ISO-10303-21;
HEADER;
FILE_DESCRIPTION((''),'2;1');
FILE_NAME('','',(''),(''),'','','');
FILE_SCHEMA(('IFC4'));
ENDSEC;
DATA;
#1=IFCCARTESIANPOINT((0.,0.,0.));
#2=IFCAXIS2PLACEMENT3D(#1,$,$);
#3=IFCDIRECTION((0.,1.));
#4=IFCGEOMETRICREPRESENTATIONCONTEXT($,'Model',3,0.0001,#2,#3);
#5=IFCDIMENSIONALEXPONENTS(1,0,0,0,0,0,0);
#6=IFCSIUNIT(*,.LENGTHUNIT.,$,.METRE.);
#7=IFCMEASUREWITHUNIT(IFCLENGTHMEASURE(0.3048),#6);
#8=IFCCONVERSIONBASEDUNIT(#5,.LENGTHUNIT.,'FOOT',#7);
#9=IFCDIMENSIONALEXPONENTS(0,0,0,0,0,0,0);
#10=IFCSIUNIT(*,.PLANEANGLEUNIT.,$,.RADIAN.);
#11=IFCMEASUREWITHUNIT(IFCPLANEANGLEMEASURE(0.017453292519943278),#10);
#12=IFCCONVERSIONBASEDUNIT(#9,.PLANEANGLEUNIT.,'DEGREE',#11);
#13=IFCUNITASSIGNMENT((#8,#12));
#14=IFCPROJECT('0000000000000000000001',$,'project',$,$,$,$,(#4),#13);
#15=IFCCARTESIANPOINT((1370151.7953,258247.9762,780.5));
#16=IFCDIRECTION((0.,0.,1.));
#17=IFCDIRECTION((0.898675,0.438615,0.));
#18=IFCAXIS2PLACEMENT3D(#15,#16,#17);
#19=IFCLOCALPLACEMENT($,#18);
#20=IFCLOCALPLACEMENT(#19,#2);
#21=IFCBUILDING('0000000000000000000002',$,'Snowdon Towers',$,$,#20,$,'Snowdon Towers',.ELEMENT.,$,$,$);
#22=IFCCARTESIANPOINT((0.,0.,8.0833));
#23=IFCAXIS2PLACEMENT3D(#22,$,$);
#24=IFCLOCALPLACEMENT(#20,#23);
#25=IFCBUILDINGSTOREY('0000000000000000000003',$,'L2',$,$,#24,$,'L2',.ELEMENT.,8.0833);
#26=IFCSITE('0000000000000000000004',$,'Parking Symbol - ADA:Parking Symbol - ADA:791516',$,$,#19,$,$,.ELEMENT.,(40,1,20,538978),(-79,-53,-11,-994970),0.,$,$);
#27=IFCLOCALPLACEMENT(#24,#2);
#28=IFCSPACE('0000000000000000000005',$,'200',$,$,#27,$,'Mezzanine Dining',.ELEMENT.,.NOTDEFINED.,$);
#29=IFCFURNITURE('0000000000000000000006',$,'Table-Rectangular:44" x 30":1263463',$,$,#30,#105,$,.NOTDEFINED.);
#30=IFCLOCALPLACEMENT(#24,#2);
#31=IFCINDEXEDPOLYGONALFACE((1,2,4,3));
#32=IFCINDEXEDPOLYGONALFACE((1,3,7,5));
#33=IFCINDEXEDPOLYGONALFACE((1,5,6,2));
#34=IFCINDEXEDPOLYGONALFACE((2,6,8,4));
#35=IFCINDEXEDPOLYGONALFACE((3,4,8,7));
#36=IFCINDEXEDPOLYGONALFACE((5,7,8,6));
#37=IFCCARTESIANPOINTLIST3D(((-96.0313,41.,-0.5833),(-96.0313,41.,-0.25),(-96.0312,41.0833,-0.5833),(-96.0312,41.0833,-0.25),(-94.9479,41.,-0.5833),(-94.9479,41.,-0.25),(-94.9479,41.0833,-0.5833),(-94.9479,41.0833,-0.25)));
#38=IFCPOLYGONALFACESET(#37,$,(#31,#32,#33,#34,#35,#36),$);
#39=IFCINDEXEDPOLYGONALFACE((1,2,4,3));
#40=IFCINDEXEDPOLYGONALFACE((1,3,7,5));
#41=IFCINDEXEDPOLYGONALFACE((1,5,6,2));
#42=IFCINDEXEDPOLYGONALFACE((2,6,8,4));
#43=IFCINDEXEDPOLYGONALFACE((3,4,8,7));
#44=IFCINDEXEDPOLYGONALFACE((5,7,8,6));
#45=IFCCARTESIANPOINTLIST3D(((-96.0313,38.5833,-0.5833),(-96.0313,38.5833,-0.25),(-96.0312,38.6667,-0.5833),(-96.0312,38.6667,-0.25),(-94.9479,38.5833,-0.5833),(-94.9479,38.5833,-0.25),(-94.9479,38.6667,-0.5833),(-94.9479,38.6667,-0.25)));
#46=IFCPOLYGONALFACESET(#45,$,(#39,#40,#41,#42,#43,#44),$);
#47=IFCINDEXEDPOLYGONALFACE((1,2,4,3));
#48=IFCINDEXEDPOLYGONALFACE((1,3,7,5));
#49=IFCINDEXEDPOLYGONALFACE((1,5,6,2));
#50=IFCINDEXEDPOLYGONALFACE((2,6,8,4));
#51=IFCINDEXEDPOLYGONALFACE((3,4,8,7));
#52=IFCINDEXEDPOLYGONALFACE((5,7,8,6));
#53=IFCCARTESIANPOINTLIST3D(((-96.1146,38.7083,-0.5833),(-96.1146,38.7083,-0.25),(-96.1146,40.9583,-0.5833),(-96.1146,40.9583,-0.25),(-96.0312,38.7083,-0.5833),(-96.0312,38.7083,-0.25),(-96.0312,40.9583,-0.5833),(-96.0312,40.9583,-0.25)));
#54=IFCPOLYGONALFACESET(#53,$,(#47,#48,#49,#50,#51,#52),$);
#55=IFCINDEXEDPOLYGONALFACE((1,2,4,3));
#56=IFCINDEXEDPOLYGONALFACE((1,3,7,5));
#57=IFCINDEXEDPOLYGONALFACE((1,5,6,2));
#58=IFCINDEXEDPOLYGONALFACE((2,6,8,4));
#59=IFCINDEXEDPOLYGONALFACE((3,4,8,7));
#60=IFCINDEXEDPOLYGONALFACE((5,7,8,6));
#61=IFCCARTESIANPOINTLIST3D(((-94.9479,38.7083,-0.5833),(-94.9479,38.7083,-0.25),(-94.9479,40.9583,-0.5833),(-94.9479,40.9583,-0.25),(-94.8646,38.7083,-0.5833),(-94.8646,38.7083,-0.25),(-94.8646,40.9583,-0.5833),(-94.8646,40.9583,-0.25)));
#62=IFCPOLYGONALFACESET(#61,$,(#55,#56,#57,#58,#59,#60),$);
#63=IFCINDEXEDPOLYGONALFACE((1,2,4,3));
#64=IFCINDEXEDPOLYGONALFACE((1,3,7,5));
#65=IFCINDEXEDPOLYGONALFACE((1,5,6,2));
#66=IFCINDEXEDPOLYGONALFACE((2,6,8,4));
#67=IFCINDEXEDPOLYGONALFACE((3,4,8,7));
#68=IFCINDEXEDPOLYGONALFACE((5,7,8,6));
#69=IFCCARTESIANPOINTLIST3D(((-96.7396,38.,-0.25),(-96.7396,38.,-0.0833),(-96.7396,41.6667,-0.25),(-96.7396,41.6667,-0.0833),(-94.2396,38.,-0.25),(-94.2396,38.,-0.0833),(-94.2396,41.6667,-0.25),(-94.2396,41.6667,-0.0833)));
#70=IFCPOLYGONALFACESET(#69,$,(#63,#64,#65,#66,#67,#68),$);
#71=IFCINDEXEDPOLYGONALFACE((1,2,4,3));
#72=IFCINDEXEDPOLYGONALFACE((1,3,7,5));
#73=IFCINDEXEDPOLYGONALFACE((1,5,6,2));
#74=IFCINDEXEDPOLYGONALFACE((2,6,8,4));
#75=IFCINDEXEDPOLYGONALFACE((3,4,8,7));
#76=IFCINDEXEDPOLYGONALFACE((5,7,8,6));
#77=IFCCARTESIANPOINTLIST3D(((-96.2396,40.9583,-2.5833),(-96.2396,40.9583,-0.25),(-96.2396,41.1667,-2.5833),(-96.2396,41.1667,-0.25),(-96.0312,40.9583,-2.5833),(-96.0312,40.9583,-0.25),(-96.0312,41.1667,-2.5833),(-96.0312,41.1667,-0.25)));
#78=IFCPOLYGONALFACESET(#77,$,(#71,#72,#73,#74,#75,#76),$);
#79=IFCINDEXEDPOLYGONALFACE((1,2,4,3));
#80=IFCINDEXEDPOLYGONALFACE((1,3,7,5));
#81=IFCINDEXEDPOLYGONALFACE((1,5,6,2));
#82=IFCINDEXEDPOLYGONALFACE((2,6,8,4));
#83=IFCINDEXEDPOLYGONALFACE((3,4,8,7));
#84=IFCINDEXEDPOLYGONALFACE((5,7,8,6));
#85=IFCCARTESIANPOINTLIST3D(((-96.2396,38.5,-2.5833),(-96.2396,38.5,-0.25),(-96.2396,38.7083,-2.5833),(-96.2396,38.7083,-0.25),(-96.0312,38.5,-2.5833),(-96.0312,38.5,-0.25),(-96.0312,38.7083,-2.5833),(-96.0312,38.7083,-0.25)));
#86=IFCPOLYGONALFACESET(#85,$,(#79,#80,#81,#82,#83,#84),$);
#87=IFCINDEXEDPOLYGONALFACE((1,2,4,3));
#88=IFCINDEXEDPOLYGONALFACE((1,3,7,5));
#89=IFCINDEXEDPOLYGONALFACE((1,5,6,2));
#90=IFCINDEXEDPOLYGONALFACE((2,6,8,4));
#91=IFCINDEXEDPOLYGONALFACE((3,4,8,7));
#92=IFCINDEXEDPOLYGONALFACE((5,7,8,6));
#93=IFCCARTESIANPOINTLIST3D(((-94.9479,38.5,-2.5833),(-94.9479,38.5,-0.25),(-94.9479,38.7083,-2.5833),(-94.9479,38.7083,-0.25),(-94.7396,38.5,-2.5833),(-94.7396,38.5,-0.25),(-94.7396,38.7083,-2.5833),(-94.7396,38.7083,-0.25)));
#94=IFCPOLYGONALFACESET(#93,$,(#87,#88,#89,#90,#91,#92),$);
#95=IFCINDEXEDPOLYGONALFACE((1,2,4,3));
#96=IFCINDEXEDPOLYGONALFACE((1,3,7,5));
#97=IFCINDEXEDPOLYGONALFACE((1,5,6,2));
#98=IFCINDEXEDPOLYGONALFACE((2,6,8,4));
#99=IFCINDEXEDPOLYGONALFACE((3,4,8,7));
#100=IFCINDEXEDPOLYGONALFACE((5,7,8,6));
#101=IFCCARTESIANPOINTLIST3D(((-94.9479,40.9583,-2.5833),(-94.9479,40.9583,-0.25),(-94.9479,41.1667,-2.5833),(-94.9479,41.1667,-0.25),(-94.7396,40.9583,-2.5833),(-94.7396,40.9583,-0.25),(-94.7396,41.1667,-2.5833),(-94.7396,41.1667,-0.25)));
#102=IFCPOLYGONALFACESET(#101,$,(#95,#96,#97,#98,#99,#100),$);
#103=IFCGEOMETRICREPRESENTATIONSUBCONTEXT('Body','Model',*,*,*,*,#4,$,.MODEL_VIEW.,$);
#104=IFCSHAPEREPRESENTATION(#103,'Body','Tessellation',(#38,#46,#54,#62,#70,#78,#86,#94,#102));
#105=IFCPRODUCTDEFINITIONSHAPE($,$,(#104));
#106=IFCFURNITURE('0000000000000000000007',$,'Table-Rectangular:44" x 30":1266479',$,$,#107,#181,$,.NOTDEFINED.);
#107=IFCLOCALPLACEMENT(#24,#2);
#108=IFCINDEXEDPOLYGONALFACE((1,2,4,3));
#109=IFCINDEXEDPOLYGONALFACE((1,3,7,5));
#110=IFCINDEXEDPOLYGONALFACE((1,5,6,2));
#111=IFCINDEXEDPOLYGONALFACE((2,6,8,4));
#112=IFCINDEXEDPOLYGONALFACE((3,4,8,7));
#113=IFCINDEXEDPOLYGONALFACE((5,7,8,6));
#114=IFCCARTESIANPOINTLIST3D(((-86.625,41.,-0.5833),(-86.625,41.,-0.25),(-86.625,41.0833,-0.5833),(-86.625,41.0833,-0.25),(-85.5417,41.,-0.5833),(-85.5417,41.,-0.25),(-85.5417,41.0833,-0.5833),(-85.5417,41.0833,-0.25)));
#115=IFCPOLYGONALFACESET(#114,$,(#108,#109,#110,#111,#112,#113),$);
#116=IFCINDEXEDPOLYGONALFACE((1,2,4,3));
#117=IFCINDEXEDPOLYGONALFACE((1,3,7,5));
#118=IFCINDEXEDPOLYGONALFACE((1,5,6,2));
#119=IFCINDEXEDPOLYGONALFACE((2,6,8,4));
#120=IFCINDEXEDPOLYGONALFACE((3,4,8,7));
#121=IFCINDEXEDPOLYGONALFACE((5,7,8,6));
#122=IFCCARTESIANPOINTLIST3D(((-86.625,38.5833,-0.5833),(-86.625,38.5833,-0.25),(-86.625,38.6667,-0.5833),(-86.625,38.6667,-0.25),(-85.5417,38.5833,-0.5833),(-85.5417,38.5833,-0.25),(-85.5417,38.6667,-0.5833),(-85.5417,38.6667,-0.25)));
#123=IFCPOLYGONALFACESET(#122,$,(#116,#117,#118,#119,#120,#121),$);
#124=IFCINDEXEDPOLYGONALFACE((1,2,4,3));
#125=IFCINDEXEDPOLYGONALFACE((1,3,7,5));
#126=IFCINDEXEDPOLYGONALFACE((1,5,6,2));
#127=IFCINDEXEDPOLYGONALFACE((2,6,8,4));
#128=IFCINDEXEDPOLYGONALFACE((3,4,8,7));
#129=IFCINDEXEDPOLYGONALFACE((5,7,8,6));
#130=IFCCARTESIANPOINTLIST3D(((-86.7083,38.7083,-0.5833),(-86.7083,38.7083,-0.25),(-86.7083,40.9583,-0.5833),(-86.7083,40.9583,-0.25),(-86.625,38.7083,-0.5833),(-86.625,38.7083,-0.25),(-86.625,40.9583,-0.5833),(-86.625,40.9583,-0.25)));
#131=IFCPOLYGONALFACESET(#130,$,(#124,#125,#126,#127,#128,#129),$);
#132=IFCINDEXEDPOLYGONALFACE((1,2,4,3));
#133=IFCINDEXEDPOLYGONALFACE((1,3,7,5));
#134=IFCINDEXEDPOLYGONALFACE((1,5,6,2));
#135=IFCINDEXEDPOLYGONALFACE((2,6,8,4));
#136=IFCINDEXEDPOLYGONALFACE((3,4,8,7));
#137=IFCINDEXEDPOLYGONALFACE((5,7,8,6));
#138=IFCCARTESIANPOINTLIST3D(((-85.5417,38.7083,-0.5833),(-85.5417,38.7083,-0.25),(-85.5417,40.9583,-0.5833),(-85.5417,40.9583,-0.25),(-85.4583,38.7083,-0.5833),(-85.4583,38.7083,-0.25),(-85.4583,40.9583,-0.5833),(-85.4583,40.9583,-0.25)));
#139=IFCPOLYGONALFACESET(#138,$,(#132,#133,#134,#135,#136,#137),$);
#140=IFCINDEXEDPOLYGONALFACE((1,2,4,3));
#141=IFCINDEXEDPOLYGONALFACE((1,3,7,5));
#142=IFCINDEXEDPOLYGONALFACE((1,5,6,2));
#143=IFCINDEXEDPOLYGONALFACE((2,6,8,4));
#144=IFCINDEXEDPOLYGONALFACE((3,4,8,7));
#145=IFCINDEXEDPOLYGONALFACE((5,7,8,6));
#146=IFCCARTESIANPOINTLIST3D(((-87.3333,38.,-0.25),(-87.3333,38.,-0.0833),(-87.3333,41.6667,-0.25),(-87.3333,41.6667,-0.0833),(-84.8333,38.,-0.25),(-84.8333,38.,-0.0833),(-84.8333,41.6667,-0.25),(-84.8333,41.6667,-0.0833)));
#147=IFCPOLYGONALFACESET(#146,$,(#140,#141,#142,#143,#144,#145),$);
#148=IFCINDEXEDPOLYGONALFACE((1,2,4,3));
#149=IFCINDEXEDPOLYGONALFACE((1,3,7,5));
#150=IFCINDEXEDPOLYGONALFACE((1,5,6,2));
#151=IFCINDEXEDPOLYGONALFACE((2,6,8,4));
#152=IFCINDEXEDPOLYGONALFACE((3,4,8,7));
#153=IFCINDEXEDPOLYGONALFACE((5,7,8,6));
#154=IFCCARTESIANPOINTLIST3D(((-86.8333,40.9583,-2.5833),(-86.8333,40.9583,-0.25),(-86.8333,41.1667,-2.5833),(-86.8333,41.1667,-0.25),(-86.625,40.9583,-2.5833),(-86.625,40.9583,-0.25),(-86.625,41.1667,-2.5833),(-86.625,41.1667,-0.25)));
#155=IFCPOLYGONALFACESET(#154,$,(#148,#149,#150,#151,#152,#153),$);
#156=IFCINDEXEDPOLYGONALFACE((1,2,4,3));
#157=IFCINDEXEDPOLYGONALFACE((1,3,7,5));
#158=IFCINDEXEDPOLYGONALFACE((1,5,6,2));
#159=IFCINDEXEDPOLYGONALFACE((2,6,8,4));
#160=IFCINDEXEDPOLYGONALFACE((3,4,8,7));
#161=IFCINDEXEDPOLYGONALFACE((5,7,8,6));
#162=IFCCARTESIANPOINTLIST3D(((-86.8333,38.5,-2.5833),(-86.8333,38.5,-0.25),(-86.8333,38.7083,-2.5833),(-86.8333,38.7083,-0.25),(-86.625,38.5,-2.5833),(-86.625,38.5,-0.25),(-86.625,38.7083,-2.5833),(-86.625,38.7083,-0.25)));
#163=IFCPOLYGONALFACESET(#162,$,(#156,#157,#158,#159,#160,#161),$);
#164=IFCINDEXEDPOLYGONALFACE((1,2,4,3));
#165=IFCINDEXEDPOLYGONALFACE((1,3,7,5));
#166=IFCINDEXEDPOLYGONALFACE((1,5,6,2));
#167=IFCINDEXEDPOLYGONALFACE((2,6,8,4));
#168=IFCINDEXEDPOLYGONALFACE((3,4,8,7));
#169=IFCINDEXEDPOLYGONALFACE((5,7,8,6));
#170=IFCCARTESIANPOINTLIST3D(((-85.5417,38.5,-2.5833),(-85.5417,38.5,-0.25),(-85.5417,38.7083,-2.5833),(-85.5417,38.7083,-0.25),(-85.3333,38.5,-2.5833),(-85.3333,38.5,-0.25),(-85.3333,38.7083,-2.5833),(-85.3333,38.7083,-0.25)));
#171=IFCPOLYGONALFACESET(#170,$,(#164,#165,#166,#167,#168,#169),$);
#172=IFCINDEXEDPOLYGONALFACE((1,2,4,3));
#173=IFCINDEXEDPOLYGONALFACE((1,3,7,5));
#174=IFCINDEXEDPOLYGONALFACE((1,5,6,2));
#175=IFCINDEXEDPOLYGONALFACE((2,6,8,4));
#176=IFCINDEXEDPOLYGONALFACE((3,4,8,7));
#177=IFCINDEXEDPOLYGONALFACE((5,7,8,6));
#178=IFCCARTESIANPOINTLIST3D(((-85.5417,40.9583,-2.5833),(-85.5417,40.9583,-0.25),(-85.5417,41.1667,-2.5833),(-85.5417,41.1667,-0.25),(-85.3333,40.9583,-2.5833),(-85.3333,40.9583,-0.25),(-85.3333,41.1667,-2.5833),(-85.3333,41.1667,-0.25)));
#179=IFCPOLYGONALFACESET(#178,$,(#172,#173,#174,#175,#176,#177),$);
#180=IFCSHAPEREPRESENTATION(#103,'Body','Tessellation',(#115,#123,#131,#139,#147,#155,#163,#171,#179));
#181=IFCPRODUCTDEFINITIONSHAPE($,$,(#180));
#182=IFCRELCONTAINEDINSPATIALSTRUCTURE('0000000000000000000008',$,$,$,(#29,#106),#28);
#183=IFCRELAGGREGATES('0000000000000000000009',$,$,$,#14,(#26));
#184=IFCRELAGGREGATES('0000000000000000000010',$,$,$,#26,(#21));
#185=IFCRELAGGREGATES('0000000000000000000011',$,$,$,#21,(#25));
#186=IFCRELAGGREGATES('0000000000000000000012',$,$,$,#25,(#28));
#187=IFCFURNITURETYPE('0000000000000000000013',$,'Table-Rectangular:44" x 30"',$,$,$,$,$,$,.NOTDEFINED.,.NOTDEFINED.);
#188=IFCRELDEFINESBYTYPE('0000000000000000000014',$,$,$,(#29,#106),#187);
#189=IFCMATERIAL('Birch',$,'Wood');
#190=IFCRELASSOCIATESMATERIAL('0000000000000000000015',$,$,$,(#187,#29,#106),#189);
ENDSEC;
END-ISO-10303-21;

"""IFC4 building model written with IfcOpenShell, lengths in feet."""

from ifc_helpers import new_model, entity, si_unit, converted_unit, direction, frame, origin, place, context, subcontext, project, spatial, indexed_curve, outline, extrude, source, transform, mapped, material, type_object, type_shapes, element, save


model = new_model("IFC4")

# Units and contexts
model_context = context("Model", 3, precision=0.0001, world=origin(), true_north=direction((0.0, 1.0)))
body_context = subcontext(model_context, "Body", "Model", "MODEL_VIEW")
ifc_project = project(units=[converted_unit("LENGTHUNIT", "FOOT", entity("IfcLengthMeasure", 0.3048), si_unit("LENGTHUNIT", "METRE"), dimensions=[1, 0, 0, 0, 0, 0, 0]), converted_unit("PLANEANGLEUNIT", "DEGREE", entity("IfcPlaneAngleMeasure", 0.017453292519943278), si_unit("PLANEANGLEUNIT", "RADIAN"), dimensions=[0, 0, 0, 0, 0, 0, 0])], contexts=[model_context])

# Site, building, storey
site_placement = place(None, frame((1370151.7953, 258247.9762, 780.5), z_axis=(0.0, 0.0, 1.0), x_axis=(0.898675, 0.438615, 0.0)))
site = spatial("IfcSite", under=ifc_project, at=site_placement, Name="Parking Symbol - ADA:Parking Symbol - ADA:791516", CompositionType="ELEMENT", RefLatitude=(40, 1, 20, 538978), RefLongitude=(-79, -53, -11, -994970), RefElevation=0.0)
building_placement = place(site_placement, origin())
building = spatial("IfcBuilding", under=site, at=building_placement, Name="Snowdon Towers", LongName="Snowdon Towers", CompositionType="ELEMENT")
storey_placement = place(building_placement, frame((0.0, 0.0, 8.0833)))
storey = spatial("IfcBuildingStorey", under=building, at=storey_placement, Name="L2", LongName="L2", CompositionType="ELEMENT", Elevation=8.0833)

# Shared definitions
space_1_placement = place(storey_placement, origin())
space_1 = spatial("IfcSpace", under=storey, at=space_1_placement, Name="200", LongName="Mezzanine Dining", CompositionType="ELEMENT", PredefinedType="NOTDEFINED")

# Furniture
ifc_material_1 = material(Name="Birch", Category="Wood")
furniture_type_1 = type_object("IfcFurnitureType", Name="Table-Rectangular:44\" x 30\"", AssemblyPlace="NOTDEFINED", PredefinedType="NOTDEFINED", material=ifc_material_1)
shared_shape_1 = source(origin(), body_context, "Body", "SweptSolid", [
    extrude(outline(indexed_curve([(-0.0417, -0.5417), (0.0417, -0.5417), (0.0417, 0.5417), (-0.0417, 0.5417), (-0.0417, -0.5417)], self_intersect=False)), frame((1.2083, 0.0, 2.0)), (0.0, 0.0, 1.0), 0.3333),
    extrude(outline(indexed_curve([(-0.5417, -0.0417), (0.5417, -0.0417), (0.5417, 0.0417), (-0.5417, 0.0417), (-0.5417, -0.0417)], self_intersect=False)), frame((-1.2083, 0.0, 2.0), z_axis=(0.0, 0.0, 1.0), x_axis=(0.0, 1.0, 0.0)), (0.0, 0.0, 1.0), 0.3333),
    extrude(outline(indexed_curve([(-1.125, -0.0417), (1.125, -0.0417), (1.125, 0.0417), (-1.125, 0.0417), (-1.125, -0.0417)], self_intersect=False)), frame((0.0, 0.5833, 2.0), z_axis=(0.0, 0.0, 1.0), x_axis=(-1.0, 0.0, 0.0)), (0.0, 0.0, 1.0), 0.3333),
    extrude(outline(indexed_curve([(-0.0417, -1.125), (0.0417, -1.125), (0.0417, 1.125), (-0.0417, 1.125), (-0.0417, -1.125)], self_intersect=False)), frame((0.0, -0.5833, 2.0), z_axis=(0.0, 0.0, 1.0), x_axis=(0.0, 1.0, 0.0)), (0.0, 0.0, 1.0), 0.3333),
    extrude(outline(indexed_curve([(-1.8333, -1.25), (1.8333, -1.25), (1.8333, 1.25), (-1.8333, 1.25), (-1.8333, -1.25)], self_intersect=False)), frame((0.0, 0.0, 2.3333), z_axis=(0.0, 0.0, 1.0), x_axis=(-1.0, 0.0, 0.0)), (0.0, 0.0, 1.0), 0.1667),
    extrude(outline(indexed_curve([(-0.1042, -0.1042), (0.1042, -0.1042), (0.1042, 0.1042), (-0.1042, 0.1042), (-0.1042, -0.1042)], self_intersect=False)), frame((1.2292, 0.6458, 0.0), z_axis=(0.0, 0.0, 1.0), x_axis=(0.0, -1.0, 0.0)), (0.0, 0.0, 1.0), 2.3333),
    extrude(outline(indexed_curve([(-0.1042, -0.1042), (0.1042, -0.1042), (0.1042, 0.1042), (-0.1042, 0.1042), (-0.1042, -0.1042)], self_intersect=False)), frame((-1.2292, 0.6458, 0.0), z_axis=(0.0, 0.0, 1.0), x_axis=(-1.0, 0.0, 0.0)), (0.0, 0.0, 1.0), 2.3333),
    extrude(outline(indexed_curve([(-0.1042, -0.1042), (0.1042, -0.1042), (0.1042, 0.1042), (-0.1042, 0.1042), (-0.1042, -0.1042)], self_intersect=False)), frame((-1.2292, -0.6458, 0.0), z_axis=(0.0, 0.0, 1.0), x_axis=(0.0, 1.0, 0.0)), (0.0, 0.0, 1.0), 2.3333),
    extrude(outline(indexed_curve([(-0.1042, -0.1042), (0.1042, -0.1042), (0.1042, 0.1042), (-0.1042, 0.1042), (-0.1042, -0.1042)], self_intersect=False)), frame((1.2292, -0.6458, 0.0)), (0.0, 0.0, 1.0), 2.3333),
])
type_shapes(furniture_type_1, [shared_shape_1])
for number, where, z_axis, x_axis, name in (
    (1, (-95.4896, 39.8333, -2.5833), (0.0, 0.0, 1.0), (0.0, 1.0, 0.0), "Table-Rectangular:44\" x 30\":1263463"),
    (2, (-86.0833, 39.8333, -2.5833), (0.0, 0.0, 1.0), (0.0, 1.0, 0.0), "Table-Rectangular:44\" x 30\":1266479"),
):
    element("IfcFurniture", number, at=place(space_1_placement, frame(where, z_axis=z_axis, x_axis=x_axis)), inside=space_1, type_object=furniture_type_1, material=ifc_material_1, Name=name, PredefinedType="NOTDEFINED", context=body_context, shape_type="MappedRepresentation", body=[
        mapped(shared_shape_1, transform((0.0, 0.0, 0.0), scale=1.0)),
    ])

save(model, "model.ifc")
